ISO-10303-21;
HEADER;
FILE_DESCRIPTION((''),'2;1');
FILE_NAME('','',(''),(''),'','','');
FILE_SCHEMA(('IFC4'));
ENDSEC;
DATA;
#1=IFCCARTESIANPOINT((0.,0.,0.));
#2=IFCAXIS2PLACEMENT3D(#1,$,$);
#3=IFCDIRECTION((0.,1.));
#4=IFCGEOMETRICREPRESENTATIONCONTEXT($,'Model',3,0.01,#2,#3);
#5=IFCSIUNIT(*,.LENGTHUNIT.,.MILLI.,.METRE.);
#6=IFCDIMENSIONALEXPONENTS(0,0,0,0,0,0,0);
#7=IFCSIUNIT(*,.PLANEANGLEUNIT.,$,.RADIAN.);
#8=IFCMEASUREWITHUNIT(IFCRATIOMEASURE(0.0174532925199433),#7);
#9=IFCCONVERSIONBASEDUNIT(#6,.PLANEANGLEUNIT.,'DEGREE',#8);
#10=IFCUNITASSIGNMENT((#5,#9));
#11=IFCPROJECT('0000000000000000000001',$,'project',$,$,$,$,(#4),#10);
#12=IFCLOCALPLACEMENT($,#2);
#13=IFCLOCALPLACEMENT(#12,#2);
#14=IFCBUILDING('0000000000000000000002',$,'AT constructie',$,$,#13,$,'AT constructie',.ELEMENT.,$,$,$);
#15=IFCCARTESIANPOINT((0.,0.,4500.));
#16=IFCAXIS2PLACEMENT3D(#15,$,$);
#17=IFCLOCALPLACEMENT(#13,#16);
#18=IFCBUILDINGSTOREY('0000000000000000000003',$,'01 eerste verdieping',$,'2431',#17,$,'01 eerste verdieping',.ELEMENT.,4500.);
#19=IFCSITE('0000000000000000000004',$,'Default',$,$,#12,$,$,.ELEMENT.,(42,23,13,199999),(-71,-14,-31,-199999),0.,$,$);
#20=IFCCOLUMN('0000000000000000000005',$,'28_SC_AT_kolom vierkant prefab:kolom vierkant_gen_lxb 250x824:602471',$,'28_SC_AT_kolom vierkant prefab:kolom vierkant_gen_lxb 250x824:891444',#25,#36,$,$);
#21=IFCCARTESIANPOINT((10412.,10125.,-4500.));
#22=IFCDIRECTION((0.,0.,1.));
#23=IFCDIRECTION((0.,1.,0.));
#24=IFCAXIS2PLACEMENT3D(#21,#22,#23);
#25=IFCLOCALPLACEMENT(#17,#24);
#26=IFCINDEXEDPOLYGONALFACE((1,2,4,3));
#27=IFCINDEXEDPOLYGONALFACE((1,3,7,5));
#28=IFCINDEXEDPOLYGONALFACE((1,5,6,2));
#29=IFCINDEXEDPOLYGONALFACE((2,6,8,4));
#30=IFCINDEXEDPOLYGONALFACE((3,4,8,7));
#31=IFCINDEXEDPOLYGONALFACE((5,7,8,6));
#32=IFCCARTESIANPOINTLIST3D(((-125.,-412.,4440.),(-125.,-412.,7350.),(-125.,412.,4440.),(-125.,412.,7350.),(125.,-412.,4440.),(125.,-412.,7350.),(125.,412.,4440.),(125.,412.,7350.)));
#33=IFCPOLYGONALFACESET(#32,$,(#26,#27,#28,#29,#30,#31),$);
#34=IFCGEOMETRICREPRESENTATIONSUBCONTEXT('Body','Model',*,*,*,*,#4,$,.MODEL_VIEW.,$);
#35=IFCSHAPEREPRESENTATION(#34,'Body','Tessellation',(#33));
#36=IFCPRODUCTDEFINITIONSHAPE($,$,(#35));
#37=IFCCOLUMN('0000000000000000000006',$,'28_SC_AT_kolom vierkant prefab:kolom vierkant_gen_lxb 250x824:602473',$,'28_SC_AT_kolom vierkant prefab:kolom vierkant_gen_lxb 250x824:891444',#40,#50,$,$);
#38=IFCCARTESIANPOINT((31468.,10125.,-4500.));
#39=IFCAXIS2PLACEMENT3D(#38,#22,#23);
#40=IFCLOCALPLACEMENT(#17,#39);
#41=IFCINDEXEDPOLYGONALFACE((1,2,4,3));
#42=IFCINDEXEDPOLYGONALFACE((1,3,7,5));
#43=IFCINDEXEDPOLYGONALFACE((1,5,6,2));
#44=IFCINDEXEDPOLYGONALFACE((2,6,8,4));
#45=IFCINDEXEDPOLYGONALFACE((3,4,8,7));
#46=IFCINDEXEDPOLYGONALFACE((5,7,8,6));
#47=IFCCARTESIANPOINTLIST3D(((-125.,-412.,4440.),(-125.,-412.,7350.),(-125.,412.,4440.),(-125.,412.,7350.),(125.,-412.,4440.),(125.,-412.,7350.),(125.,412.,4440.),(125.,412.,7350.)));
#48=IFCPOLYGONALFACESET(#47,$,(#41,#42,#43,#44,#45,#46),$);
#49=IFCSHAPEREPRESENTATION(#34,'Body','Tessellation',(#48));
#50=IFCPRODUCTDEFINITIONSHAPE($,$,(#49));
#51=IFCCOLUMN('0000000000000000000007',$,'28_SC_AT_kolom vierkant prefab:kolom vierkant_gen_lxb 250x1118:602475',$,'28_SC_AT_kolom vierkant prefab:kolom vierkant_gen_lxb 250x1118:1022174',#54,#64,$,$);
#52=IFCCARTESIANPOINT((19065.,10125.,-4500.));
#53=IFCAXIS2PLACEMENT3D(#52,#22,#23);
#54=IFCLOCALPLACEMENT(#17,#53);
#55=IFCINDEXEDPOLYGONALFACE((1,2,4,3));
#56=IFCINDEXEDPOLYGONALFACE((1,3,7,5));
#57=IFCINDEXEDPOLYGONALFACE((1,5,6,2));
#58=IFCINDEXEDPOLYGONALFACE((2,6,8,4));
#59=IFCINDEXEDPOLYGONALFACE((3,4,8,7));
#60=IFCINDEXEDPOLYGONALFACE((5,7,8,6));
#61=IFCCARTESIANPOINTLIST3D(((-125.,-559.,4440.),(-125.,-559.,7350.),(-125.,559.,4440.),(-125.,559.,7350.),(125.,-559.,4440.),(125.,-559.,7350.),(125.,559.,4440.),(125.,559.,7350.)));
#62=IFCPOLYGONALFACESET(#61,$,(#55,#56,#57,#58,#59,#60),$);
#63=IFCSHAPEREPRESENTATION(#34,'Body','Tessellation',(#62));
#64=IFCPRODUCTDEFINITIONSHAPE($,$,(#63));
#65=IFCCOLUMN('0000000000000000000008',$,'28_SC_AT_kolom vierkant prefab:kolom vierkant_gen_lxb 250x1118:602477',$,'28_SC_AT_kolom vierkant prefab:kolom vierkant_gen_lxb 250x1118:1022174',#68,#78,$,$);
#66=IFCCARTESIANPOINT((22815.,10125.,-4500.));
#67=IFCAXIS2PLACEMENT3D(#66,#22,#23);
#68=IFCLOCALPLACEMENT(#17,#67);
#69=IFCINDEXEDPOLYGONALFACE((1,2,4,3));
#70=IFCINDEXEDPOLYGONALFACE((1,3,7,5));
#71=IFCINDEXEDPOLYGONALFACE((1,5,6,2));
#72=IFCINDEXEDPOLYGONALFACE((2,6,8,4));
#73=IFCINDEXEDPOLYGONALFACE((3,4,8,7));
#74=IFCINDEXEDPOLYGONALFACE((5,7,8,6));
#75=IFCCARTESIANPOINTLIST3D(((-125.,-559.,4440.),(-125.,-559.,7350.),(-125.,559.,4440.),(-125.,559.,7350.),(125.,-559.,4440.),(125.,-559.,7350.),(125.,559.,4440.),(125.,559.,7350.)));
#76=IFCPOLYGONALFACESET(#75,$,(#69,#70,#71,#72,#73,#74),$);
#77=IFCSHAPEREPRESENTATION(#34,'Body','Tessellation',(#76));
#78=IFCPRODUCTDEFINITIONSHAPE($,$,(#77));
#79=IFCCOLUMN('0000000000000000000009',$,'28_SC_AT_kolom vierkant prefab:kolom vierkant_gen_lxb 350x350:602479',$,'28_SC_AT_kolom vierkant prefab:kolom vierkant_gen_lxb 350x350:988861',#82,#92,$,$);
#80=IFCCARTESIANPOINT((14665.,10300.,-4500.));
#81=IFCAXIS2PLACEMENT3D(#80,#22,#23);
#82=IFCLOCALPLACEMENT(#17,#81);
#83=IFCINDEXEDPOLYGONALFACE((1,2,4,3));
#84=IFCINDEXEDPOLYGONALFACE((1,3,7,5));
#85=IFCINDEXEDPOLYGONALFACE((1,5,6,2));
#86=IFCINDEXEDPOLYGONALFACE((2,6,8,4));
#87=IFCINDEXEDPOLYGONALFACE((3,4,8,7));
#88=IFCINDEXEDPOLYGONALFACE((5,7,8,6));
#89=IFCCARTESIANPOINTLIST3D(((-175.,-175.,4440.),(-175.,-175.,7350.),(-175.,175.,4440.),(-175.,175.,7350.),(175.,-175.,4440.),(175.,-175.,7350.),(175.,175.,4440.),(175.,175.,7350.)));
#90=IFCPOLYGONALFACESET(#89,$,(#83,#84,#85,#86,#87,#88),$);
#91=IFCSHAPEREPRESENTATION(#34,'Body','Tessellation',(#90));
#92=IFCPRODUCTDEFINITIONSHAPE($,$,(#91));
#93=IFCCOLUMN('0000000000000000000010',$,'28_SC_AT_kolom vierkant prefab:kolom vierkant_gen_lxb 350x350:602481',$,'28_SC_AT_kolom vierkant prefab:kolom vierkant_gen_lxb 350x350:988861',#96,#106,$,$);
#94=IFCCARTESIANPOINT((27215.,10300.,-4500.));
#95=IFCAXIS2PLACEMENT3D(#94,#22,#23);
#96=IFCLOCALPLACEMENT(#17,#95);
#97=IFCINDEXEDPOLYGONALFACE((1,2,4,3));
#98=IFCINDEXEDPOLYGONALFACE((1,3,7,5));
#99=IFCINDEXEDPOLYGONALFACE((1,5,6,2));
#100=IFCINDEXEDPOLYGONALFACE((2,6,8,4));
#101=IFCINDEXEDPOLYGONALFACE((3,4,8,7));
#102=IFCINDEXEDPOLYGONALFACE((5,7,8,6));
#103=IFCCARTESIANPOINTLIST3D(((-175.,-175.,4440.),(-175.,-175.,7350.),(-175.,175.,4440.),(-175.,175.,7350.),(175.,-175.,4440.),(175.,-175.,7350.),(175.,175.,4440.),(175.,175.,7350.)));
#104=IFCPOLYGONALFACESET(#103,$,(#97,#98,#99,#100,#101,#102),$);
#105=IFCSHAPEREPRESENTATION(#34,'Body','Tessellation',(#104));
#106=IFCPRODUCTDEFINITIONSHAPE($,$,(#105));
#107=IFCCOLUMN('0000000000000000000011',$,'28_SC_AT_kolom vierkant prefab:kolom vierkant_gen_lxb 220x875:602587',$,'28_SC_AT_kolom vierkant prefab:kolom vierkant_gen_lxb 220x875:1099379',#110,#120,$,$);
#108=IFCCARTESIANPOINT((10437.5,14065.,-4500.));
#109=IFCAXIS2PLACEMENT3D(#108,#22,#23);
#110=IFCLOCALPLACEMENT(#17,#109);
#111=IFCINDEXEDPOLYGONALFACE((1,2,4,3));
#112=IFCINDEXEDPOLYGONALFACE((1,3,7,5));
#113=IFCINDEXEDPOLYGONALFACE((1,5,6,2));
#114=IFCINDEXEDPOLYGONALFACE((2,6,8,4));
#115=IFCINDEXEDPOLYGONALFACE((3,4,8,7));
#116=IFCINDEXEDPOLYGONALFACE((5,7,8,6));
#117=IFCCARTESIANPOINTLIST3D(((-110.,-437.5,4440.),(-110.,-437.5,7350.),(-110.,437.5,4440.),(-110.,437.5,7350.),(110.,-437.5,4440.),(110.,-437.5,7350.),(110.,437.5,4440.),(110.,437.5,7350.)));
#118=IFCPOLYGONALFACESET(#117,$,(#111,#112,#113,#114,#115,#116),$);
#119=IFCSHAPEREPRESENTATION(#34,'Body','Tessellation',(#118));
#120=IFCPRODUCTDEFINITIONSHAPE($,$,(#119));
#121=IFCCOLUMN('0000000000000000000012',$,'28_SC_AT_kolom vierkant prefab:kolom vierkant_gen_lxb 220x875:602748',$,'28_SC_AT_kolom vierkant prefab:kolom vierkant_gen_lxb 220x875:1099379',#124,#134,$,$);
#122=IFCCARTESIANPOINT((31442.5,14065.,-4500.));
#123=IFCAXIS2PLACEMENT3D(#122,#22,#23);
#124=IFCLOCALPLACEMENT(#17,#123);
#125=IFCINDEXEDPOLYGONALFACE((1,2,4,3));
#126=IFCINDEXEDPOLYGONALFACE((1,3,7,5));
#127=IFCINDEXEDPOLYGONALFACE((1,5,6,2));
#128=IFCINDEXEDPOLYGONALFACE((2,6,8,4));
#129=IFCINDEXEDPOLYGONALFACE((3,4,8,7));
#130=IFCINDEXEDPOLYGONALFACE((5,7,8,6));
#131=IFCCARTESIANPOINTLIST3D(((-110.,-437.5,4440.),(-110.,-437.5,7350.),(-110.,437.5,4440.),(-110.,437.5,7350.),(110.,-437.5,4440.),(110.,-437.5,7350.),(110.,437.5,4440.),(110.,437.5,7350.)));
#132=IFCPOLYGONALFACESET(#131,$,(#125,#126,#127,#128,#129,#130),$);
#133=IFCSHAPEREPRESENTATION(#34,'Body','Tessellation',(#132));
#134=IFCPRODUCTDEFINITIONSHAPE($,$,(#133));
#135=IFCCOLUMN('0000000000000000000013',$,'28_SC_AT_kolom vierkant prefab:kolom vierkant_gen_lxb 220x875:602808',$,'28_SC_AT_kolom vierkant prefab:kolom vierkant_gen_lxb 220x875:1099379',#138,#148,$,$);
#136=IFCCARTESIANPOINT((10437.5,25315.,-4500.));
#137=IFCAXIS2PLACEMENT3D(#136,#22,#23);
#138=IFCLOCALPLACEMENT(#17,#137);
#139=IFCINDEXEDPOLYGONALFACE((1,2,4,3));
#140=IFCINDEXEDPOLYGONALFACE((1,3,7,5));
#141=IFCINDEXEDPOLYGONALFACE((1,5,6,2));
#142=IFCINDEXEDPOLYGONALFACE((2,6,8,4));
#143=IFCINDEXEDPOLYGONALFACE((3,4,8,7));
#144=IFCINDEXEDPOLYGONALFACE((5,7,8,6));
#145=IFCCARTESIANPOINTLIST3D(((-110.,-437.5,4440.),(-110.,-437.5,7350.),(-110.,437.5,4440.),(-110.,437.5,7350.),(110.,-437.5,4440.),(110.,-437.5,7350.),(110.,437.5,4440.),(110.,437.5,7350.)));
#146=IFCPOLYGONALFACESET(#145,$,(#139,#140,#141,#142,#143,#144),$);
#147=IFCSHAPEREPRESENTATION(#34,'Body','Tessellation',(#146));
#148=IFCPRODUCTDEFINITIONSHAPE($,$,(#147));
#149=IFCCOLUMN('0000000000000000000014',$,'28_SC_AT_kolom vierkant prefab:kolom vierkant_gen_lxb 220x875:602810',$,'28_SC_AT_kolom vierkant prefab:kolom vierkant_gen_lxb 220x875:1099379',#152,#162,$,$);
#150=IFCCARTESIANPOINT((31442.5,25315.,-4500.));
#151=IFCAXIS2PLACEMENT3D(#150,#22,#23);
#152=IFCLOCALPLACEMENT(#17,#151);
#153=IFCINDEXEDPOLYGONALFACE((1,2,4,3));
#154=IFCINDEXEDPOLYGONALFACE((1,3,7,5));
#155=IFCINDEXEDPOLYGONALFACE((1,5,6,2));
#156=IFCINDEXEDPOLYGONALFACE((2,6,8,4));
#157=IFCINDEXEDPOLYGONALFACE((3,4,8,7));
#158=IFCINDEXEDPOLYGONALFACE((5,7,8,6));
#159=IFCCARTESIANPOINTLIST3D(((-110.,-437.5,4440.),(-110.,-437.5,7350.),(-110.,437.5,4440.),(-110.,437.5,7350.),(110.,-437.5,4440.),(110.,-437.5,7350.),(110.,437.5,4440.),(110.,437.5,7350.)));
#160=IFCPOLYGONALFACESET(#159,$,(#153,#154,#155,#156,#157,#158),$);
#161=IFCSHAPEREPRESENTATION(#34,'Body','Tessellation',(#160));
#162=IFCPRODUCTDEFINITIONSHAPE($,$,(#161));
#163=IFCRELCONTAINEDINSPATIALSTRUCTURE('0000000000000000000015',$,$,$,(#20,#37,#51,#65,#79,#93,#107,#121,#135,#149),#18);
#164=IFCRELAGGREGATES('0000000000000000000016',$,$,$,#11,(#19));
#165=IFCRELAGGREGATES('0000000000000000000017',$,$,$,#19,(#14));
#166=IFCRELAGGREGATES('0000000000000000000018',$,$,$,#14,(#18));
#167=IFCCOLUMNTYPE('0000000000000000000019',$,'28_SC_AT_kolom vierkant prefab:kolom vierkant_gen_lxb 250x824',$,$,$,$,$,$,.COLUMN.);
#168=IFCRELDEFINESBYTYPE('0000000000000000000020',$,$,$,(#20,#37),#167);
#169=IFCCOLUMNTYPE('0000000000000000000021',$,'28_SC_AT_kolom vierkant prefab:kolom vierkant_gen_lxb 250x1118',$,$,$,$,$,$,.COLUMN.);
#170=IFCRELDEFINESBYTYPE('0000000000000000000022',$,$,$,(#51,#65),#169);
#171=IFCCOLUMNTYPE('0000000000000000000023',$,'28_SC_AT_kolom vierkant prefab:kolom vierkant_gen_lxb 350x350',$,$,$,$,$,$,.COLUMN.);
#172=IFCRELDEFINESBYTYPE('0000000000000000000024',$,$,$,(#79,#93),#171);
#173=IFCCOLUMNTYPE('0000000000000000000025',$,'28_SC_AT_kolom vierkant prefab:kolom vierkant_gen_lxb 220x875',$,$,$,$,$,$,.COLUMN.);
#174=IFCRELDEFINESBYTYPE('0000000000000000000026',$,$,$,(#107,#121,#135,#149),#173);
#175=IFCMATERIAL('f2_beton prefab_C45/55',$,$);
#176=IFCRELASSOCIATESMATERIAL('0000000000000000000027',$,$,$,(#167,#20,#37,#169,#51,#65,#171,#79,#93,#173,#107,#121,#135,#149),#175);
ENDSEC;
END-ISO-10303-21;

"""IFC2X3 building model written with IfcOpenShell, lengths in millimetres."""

from ifc_helpers import new_model, entity, si_unit, converted_unit, direction, frame, origin, origin_2d_with_axis, place, context, subcontext, project, spatial, rectangle, extrude, source, transform, mapped, material, type_object, type_shapes, element, save


model = new_model("IFC2X3")

# Units and contexts
model_context = context("Model", 3, precision=0.01, world=origin(), true_north=direction((0.0, 1.0)))
body_context = subcontext(model_context, "Body", "Model", "MODEL_VIEW")
ifc_project = project(units=[si_unit("LENGTHUNIT", "METRE", prefix="MILLI"), converted_unit("PLANEANGLEUNIT", "DEGREE", entity("IfcRatioMeasure", 0.0174532925199433), si_unit("PLANEANGLEUNIT", "RADIAN"), dimensions=[0, 0, 0, 0, 0, 0, 0])], contexts=[model_context])

# Site, building, storey
site_placement = place(None, origin())
site = spatial("IfcSite", under=ifc_project, at=site_placement, Name="Default", CompositionType="ELEMENT", RefLatitude=(42, 23, 13, 199999), RefLongitude=(-71, -14, -31, -199999), RefElevation=0.0)
building_placement = place(site_placement, origin())
building = spatial("IfcBuilding", under=site, at=building_placement, Name="AT constructie", LongName="AT constructie", CompositionType="ELEMENT")
storey_placement = place(building_placement, frame((0.0, 0.0, 4500.0)))
storey = spatial("IfcBuildingStorey", under=building, at=storey_placement, Name="01 eerste verdieping", ObjectType="2431", LongName="01 eerste verdieping", CompositionType="ELEMENT", Elevation=4500.0)

# Columns
ifc_material_1 = material(Name="f2_beton prefab_C45/55")
column_type_1 = type_object("IfcColumnType", Name="28_SC_AT_kolom vierkant prefab:kolom vierkant_gen_lxb 250x824", PredefinedType="COLUMN", material=ifc_material_1)
shared_shape_1 = source(origin(), body_context, "Body", "SweptSolid", [
    extrude(rectangle(XDim=250.0, YDim=824.0, at=origin_2d_with_axis()), frame((0.0, 0.0, 4440.0), z_axis=(0.0, 0.0, 1.0), x_axis=(-1.0, 0.0, 0.0)), (0.0, 0.0, 1.0), 2910.0),
])
type_shapes(column_type_1, [shared_shape_1])
for number, where, z_axis, x_axis, name in (
    (1, (10412.0, 10125.0, -4500.0), (0.0, 0.0, 1.0), (0.0, 1.0, 0.0), "28_SC_AT_kolom vierkant prefab:kolom vierkant_gen_lxb 250x824:602471"),
    (2, (31468.0, 10125.0, -4500.0), (0.0, 0.0, 1.0), (0.0, 1.0, 0.0), "28_SC_AT_kolom vierkant prefab:kolom vierkant_gen_lxb 250x824:602473"),
):
    element("IfcColumn", number, at=place(storey_placement, frame(where, z_axis=z_axis, x_axis=x_axis)), inside=storey, type_object=column_type_1, material=ifc_material_1, Name=name, ObjectType="28_SC_AT_kolom vierkant prefab:kolom vierkant_gen_lxb 250x824:891444", context=body_context, shape_type="MappedRepresentation", body=[
        mapped(shared_shape_1, transform((0.0, 0.0, 0.0), scale=1.0)),
    ])
column_type_2 = type_object("IfcColumnType", Name="28_SC_AT_kolom vierkant prefab:kolom vierkant_gen_lxb 250x1118", PredefinedType="COLUMN", material=ifc_material_1)
shared_shape_2 = source(origin(), body_context, "Body", "SweptSolid", [
    extrude(rectangle(XDim=250.0, YDim=1118.0, at=origin_2d_with_axis()), frame((0.0, 0.0, 4440.0), z_axis=(0.0, 0.0, 1.0), x_axis=(-1.0, 0.0, 0.0)), (0.0, 0.0, 1.0), 2910.0),
])
type_shapes(column_type_2, [shared_shape_2])
for number, where, z_axis, x_axis, name in (
    (3, (19065.0, 10125.0, -4500.0), (0.0, 0.0, 1.0), (0.0, 1.0, 0.0), "28_SC_AT_kolom vierkant prefab:kolom vierkant_gen_lxb 250x1118:602475"),
    (4, (22815.0, 10125.0, -4500.0), (0.0, 0.0, 1.0), (0.0, 1.0, 0.0), "28_SC_AT_kolom vierkant prefab:kolom vierkant_gen_lxb 250x1118:602477"),
):
    element("IfcColumn", number, at=place(storey_placement, frame(where, z_axis=z_axis, x_axis=x_axis)), inside=storey, type_object=column_type_2, material=ifc_material_1, Name=name, ObjectType="28_SC_AT_kolom vierkant prefab:kolom vierkant_gen_lxb 250x1118:1022174", context=body_context, shape_type="MappedRepresentation", body=[
        mapped(shared_shape_2, transform((0.0, 0.0, 0.0), scale=1.0)),
    ])
column_type_3 = type_object("IfcColumnType", Name="28_SC_AT_kolom vierkant prefab:kolom vierkant_gen_lxb 350x350", PredefinedType="COLUMN", material=ifc_material_1)
shared_shape_3 = source(origin(), body_context, "Body", "SweptSolid", [
    extrude(rectangle(XDim=350.0, YDim=350.0, at=origin_2d_with_axis()), frame((0.0, 0.0, 4440.0), z_axis=(0.0, 0.0, 1.0), x_axis=(-1.0, 0.0, 0.0)), (0.0, 0.0, 1.0), 2910.0),
])
type_shapes(column_type_3, [shared_shape_3])
for number, where, z_axis, x_axis, name in (
    (5, (14665.0, 10300.0, -4500.0), (0.0, 0.0, 1.0), (0.0, 1.0, 0.0), "28_SC_AT_kolom vierkant prefab:kolom vierkant_gen_lxb 350x350:602479"),
    (6, (27215.0, 10300.0, -4500.0), (0.0, 0.0, 1.0), (0.0, 1.0, 0.0), "28_SC_AT_kolom vierkant prefab:kolom vierkant_gen_lxb 350x350:602481"),
):
    element("IfcColumn", number, at=place(storey_placement, frame(where, z_axis=z_axis, x_axis=x_axis)), inside=storey, type_object=column_type_3, material=ifc_material_1, Name=name, ObjectType="28_SC_AT_kolom vierkant prefab:kolom vierkant_gen_lxb 350x350:988861", context=body_context, shape_type="MappedRepresentation", body=[
        mapped(shared_shape_3, transform((0.0, 0.0, 0.0), scale=1.0)),
    ])
column_type_4 = type_object("IfcColumnType", Name="28_SC_AT_kolom vierkant prefab:kolom vierkant_gen_lxb 220x875", PredefinedType="COLUMN", material=ifc_material_1)
shared_shape_4 = source(origin(), body_context, "Body", "SweptSolid", [
    extrude(rectangle(XDim=220.0, YDim=875.0, at=origin_2d_with_axis()), frame((0.0, 0.0, 4440.0), z_axis=(0.0, 0.0, 1.0), x_axis=(-1.0, 0.0, 0.0)), (0.0, 0.0, 1.0), 2910.0),
])
type_shapes(column_type_4, [shared_shape_4])
for number, where, z_axis, x_axis, name in (
    (7, (10437.5, 14065.0, -4500.0), (0.0, 0.0, 1.0), (0.0, 1.0, 0.0), "28_SC_AT_kolom vierkant prefab:kolom vierkant_gen_lxb 220x875:602587"),
    (8, (31442.5, 14065.0, -4500.0), (0.0, 0.0, 1.0), (0.0, 1.0, 0.0), "28_SC_AT_kolom vierkant prefab:kolom vierkant_gen_lxb 220x875:602748"),
    (9, (10437.5, 25315.0, -4500.0), (0.0, 0.0, 1.0), (0.0, 1.0, 0.0), "28_SC_AT_kolom vierkant prefab:kolom vierkant_gen_lxb 220x875:602808"),
    (10, (31442.5, 25315.0, -4500.0), (0.0, 0.0, 1.0), (0.0, 1.0, 0.0), "28_SC_AT_kolom vierkant prefab:kolom vierkant_gen_lxb 220x875:602810"),
):
    element("IfcColumn", number, at=place(storey_placement, frame(where, z_axis=z_axis, x_axis=x_axis)), inside=storey, type_object=column_type_4, material=ifc_material_1, Name=name, ObjectType="28_SC_AT_kolom vierkant prefab:kolom vierkant_gen_lxb 220x875:1099379", context=body_context, shape_type="MappedRepresentation", body=[
        mapped(shared_shape_4, transform((0.0, 0.0, 0.0), scale=1.0)),
    ])

save(model, "model.ifc")
